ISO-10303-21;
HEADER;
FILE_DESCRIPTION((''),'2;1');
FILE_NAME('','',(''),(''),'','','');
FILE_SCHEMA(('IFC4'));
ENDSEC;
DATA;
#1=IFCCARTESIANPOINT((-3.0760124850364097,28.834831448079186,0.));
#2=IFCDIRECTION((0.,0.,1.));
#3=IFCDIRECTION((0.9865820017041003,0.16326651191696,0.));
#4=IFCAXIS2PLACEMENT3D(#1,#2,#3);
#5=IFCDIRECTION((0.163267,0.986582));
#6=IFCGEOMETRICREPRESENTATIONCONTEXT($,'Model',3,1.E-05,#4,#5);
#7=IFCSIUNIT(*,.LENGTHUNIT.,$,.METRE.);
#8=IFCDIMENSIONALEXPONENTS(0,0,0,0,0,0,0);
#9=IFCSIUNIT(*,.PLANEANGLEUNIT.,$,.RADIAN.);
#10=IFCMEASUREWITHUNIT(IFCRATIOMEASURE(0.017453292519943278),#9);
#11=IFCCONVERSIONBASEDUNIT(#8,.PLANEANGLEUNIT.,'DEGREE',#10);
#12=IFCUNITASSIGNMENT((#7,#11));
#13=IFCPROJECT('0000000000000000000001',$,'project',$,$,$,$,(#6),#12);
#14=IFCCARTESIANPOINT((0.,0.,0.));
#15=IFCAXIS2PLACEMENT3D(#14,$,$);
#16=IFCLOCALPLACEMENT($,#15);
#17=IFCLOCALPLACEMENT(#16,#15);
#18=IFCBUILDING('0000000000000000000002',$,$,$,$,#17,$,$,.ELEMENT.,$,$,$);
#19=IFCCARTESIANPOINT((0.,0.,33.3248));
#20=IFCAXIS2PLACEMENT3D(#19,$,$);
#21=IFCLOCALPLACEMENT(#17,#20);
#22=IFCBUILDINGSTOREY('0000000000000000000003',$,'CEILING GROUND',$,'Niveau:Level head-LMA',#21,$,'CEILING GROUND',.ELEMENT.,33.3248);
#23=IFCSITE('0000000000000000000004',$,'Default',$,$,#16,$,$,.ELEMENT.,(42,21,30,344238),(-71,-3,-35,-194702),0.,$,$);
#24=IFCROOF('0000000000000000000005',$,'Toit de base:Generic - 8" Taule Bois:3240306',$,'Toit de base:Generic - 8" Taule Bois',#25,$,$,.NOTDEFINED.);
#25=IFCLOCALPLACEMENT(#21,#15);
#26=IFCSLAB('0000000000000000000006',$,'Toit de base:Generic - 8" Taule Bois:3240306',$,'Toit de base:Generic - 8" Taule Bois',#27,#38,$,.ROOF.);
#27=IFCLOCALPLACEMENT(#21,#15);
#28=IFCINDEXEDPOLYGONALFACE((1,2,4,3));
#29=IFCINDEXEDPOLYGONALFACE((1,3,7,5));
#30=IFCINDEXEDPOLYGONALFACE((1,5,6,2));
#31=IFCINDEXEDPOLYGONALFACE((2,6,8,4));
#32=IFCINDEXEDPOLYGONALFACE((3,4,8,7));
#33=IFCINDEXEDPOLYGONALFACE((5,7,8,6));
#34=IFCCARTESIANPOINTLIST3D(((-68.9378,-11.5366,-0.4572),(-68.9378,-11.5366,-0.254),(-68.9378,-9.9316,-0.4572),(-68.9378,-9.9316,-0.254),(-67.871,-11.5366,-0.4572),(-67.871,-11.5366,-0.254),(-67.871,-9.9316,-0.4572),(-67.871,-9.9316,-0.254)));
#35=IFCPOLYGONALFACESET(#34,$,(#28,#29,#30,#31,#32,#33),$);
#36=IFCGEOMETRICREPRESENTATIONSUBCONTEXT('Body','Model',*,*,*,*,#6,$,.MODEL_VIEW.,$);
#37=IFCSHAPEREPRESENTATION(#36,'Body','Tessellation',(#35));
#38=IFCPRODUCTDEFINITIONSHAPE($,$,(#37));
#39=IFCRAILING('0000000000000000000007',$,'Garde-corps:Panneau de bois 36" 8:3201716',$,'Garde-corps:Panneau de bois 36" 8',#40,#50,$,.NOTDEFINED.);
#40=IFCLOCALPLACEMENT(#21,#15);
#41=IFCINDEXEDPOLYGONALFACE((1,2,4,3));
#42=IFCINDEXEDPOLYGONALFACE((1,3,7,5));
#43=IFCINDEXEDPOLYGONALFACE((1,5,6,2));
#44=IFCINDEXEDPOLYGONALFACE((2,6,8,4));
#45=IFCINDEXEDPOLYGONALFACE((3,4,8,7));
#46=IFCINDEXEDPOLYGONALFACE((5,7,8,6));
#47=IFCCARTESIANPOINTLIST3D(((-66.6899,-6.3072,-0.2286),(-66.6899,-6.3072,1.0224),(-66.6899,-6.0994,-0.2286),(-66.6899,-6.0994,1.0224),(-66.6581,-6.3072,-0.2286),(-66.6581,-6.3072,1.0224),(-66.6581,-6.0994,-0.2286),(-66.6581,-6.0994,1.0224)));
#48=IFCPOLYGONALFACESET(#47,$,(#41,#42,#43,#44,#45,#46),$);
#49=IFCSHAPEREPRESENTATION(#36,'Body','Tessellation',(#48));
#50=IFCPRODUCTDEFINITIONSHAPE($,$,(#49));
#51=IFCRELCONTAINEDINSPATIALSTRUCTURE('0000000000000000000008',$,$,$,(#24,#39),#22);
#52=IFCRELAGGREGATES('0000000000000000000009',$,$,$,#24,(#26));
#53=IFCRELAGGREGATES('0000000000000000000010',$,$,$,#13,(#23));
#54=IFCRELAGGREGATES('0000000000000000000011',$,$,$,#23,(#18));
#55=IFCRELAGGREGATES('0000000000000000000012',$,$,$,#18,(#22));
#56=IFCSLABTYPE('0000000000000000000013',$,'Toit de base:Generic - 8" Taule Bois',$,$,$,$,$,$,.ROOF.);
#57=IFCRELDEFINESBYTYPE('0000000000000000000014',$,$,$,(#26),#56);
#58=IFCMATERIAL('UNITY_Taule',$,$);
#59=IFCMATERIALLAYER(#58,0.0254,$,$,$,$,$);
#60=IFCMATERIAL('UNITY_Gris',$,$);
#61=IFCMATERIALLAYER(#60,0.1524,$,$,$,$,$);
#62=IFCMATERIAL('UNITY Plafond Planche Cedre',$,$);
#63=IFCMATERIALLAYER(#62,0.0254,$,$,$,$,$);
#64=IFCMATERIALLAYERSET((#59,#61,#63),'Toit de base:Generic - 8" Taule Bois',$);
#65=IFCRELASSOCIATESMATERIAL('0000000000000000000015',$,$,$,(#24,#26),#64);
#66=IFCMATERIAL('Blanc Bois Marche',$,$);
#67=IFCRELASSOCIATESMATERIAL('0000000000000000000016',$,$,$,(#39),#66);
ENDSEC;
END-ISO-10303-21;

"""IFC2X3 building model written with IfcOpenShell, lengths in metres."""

from ifc_helpers import new_model, entity, si_unit, converted_unit, direction, frame, frame_2d, origin, place, context, subcontext, project, spatial, rectangle, extrude, material, layer, layer_set, type_object, element, aggregate, save


model = new_model("IFC2X3")

# Units and contexts
model_context = context("Model", 3, precision=1e-05, world=frame((-3.0760124850364097, 28.834831448079186, 0.0), z_axis=(0.0, 0.0, 1.0), x_axis=(0.9865820017041003, 0.16326651191696, 0.0)), true_north=direction((0.163267, 0.986582)))
body_context = subcontext(model_context, "Body", "Model", "MODEL_VIEW")
ifc_project = project(units=[si_unit("LENGTHUNIT", "METRE"), converted_unit("PLANEANGLEUNIT", "DEGREE", entity("IfcRatioMeasure", 0.017453292519943278), si_unit("PLANEANGLEUNIT", "RADIAN"), dimensions=[0, 0, 0, 0, 0, 0, 0])], contexts=[model_context])

# Site, building, storey
site_placement = place(None, origin())
site = spatial("IfcSite", under=ifc_project, at=site_placement, Name="Default", CompositionType="ELEMENT", RefLatitude=(42, 21, 30, 344238), RefLongitude=(-71, -3, -35, -194702), RefElevation=0.0)
building_placement = place(site_placement, origin())
building = spatial("IfcBuilding", under=site, at=building_placement, CompositionType="ELEMENT")
storey_placement = place(building_placement, frame((0.0, 0.0, 33.3248)))
storey = spatial("IfcBuildingStorey", under=building, at=storey_placement, Name="CEILING GROUND", ObjectType="Niveau:Level head-LMA", LongName="CEILING GROUND", CompositionType="ELEMENT", Elevation=33.3248)

# Roof, slab
ifc_material_1 = material(Name="UNITY_Taule")
ifc_layer_1 = layer(ifc_material_1, 0.0254)
ifc_material_2 = material(Name="UNITY_Gris")
ifc_layer_2 = layer(ifc_material_2, 0.1524)
ifc_material_3 = material(Name="UNITY Plafond Planche Cedre")
ifc_layer_3 = layer(ifc_material_3, 0.0254)
ifc_layer_set = layer_set([ifc_layer_1, ifc_layer_2, ifc_layer_3], Name="Toit de base:Generic - 8\" Taule Bois")
roof_placement = place(storey_placement, frame((-68.9378, -11.5366, -0.4572)))
roof = element("IfcRoof", 1, at=roof_placement, inside=storey, material=ifc_layer_set, Name="Toit de base:Generic - 8\" Taule Bois:3240306", ObjectType="Toit de base:Generic - 8\" Taule Bois", ShapeType="NOTDEFINED")
slab_type = type_object("IfcSlabType", Name="Toit de base:Generic - 8\" Taule Bois", PredefinedType="ROOF")
slab_placement = place(roof_placement, origin())
slab = element("IfcSlab", 2, at=slab_placement, type_object=slab_type, material=ifc_layer_set, Name="Toit de base:Generic - 8\" Taule Bois:3240306", ObjectType="Toit de base:Generic - 8\" Taule Bois", PredefinedType="ROOF", context=body_context, shape_type="SweptSolid", body=[
    extrude(rectangle(XDim=1.0668, YDim=1.605, at=frame_2d((0.0, 0.0), x_axis=(-1.0, 0.0))), frame((0.5334, 0.8025, 0.0)), (0.0, 0.0, 1.0), 0.2032),
])
aggregate(roof, [slab])

# Railing
ifc_material_4 = material(Name="Blanc Bois Marche")
railing_1_placement = place(storey_placement, origin())
element("IfcRailing", 3, at=railing_1_placement, inside=storey, material=ifc_material_4, Name="Garde-corps:Panneau de bois 36\" 8:3201716", ObjectType="Garde-corps:Panneau de bois 36\" 8", PredefinedType="NOTDEFINED", context=body_context, shape_type="SweptSolid", body=[
    extrude(rectangle(XDim=0.2078, YDim=0.0317, at=frame_2d((0.0, 0.0), x_axis=(1.0, 0.0))), frame((-66.674, -6.2033, -0.2286), z_axis=(0.0, 0.0, 1.0), x_axis=(0.0, 1.0, 0.0)), (0.0, 0.0, 1.0), 1.251),
])

save(model, "model.ifc")
